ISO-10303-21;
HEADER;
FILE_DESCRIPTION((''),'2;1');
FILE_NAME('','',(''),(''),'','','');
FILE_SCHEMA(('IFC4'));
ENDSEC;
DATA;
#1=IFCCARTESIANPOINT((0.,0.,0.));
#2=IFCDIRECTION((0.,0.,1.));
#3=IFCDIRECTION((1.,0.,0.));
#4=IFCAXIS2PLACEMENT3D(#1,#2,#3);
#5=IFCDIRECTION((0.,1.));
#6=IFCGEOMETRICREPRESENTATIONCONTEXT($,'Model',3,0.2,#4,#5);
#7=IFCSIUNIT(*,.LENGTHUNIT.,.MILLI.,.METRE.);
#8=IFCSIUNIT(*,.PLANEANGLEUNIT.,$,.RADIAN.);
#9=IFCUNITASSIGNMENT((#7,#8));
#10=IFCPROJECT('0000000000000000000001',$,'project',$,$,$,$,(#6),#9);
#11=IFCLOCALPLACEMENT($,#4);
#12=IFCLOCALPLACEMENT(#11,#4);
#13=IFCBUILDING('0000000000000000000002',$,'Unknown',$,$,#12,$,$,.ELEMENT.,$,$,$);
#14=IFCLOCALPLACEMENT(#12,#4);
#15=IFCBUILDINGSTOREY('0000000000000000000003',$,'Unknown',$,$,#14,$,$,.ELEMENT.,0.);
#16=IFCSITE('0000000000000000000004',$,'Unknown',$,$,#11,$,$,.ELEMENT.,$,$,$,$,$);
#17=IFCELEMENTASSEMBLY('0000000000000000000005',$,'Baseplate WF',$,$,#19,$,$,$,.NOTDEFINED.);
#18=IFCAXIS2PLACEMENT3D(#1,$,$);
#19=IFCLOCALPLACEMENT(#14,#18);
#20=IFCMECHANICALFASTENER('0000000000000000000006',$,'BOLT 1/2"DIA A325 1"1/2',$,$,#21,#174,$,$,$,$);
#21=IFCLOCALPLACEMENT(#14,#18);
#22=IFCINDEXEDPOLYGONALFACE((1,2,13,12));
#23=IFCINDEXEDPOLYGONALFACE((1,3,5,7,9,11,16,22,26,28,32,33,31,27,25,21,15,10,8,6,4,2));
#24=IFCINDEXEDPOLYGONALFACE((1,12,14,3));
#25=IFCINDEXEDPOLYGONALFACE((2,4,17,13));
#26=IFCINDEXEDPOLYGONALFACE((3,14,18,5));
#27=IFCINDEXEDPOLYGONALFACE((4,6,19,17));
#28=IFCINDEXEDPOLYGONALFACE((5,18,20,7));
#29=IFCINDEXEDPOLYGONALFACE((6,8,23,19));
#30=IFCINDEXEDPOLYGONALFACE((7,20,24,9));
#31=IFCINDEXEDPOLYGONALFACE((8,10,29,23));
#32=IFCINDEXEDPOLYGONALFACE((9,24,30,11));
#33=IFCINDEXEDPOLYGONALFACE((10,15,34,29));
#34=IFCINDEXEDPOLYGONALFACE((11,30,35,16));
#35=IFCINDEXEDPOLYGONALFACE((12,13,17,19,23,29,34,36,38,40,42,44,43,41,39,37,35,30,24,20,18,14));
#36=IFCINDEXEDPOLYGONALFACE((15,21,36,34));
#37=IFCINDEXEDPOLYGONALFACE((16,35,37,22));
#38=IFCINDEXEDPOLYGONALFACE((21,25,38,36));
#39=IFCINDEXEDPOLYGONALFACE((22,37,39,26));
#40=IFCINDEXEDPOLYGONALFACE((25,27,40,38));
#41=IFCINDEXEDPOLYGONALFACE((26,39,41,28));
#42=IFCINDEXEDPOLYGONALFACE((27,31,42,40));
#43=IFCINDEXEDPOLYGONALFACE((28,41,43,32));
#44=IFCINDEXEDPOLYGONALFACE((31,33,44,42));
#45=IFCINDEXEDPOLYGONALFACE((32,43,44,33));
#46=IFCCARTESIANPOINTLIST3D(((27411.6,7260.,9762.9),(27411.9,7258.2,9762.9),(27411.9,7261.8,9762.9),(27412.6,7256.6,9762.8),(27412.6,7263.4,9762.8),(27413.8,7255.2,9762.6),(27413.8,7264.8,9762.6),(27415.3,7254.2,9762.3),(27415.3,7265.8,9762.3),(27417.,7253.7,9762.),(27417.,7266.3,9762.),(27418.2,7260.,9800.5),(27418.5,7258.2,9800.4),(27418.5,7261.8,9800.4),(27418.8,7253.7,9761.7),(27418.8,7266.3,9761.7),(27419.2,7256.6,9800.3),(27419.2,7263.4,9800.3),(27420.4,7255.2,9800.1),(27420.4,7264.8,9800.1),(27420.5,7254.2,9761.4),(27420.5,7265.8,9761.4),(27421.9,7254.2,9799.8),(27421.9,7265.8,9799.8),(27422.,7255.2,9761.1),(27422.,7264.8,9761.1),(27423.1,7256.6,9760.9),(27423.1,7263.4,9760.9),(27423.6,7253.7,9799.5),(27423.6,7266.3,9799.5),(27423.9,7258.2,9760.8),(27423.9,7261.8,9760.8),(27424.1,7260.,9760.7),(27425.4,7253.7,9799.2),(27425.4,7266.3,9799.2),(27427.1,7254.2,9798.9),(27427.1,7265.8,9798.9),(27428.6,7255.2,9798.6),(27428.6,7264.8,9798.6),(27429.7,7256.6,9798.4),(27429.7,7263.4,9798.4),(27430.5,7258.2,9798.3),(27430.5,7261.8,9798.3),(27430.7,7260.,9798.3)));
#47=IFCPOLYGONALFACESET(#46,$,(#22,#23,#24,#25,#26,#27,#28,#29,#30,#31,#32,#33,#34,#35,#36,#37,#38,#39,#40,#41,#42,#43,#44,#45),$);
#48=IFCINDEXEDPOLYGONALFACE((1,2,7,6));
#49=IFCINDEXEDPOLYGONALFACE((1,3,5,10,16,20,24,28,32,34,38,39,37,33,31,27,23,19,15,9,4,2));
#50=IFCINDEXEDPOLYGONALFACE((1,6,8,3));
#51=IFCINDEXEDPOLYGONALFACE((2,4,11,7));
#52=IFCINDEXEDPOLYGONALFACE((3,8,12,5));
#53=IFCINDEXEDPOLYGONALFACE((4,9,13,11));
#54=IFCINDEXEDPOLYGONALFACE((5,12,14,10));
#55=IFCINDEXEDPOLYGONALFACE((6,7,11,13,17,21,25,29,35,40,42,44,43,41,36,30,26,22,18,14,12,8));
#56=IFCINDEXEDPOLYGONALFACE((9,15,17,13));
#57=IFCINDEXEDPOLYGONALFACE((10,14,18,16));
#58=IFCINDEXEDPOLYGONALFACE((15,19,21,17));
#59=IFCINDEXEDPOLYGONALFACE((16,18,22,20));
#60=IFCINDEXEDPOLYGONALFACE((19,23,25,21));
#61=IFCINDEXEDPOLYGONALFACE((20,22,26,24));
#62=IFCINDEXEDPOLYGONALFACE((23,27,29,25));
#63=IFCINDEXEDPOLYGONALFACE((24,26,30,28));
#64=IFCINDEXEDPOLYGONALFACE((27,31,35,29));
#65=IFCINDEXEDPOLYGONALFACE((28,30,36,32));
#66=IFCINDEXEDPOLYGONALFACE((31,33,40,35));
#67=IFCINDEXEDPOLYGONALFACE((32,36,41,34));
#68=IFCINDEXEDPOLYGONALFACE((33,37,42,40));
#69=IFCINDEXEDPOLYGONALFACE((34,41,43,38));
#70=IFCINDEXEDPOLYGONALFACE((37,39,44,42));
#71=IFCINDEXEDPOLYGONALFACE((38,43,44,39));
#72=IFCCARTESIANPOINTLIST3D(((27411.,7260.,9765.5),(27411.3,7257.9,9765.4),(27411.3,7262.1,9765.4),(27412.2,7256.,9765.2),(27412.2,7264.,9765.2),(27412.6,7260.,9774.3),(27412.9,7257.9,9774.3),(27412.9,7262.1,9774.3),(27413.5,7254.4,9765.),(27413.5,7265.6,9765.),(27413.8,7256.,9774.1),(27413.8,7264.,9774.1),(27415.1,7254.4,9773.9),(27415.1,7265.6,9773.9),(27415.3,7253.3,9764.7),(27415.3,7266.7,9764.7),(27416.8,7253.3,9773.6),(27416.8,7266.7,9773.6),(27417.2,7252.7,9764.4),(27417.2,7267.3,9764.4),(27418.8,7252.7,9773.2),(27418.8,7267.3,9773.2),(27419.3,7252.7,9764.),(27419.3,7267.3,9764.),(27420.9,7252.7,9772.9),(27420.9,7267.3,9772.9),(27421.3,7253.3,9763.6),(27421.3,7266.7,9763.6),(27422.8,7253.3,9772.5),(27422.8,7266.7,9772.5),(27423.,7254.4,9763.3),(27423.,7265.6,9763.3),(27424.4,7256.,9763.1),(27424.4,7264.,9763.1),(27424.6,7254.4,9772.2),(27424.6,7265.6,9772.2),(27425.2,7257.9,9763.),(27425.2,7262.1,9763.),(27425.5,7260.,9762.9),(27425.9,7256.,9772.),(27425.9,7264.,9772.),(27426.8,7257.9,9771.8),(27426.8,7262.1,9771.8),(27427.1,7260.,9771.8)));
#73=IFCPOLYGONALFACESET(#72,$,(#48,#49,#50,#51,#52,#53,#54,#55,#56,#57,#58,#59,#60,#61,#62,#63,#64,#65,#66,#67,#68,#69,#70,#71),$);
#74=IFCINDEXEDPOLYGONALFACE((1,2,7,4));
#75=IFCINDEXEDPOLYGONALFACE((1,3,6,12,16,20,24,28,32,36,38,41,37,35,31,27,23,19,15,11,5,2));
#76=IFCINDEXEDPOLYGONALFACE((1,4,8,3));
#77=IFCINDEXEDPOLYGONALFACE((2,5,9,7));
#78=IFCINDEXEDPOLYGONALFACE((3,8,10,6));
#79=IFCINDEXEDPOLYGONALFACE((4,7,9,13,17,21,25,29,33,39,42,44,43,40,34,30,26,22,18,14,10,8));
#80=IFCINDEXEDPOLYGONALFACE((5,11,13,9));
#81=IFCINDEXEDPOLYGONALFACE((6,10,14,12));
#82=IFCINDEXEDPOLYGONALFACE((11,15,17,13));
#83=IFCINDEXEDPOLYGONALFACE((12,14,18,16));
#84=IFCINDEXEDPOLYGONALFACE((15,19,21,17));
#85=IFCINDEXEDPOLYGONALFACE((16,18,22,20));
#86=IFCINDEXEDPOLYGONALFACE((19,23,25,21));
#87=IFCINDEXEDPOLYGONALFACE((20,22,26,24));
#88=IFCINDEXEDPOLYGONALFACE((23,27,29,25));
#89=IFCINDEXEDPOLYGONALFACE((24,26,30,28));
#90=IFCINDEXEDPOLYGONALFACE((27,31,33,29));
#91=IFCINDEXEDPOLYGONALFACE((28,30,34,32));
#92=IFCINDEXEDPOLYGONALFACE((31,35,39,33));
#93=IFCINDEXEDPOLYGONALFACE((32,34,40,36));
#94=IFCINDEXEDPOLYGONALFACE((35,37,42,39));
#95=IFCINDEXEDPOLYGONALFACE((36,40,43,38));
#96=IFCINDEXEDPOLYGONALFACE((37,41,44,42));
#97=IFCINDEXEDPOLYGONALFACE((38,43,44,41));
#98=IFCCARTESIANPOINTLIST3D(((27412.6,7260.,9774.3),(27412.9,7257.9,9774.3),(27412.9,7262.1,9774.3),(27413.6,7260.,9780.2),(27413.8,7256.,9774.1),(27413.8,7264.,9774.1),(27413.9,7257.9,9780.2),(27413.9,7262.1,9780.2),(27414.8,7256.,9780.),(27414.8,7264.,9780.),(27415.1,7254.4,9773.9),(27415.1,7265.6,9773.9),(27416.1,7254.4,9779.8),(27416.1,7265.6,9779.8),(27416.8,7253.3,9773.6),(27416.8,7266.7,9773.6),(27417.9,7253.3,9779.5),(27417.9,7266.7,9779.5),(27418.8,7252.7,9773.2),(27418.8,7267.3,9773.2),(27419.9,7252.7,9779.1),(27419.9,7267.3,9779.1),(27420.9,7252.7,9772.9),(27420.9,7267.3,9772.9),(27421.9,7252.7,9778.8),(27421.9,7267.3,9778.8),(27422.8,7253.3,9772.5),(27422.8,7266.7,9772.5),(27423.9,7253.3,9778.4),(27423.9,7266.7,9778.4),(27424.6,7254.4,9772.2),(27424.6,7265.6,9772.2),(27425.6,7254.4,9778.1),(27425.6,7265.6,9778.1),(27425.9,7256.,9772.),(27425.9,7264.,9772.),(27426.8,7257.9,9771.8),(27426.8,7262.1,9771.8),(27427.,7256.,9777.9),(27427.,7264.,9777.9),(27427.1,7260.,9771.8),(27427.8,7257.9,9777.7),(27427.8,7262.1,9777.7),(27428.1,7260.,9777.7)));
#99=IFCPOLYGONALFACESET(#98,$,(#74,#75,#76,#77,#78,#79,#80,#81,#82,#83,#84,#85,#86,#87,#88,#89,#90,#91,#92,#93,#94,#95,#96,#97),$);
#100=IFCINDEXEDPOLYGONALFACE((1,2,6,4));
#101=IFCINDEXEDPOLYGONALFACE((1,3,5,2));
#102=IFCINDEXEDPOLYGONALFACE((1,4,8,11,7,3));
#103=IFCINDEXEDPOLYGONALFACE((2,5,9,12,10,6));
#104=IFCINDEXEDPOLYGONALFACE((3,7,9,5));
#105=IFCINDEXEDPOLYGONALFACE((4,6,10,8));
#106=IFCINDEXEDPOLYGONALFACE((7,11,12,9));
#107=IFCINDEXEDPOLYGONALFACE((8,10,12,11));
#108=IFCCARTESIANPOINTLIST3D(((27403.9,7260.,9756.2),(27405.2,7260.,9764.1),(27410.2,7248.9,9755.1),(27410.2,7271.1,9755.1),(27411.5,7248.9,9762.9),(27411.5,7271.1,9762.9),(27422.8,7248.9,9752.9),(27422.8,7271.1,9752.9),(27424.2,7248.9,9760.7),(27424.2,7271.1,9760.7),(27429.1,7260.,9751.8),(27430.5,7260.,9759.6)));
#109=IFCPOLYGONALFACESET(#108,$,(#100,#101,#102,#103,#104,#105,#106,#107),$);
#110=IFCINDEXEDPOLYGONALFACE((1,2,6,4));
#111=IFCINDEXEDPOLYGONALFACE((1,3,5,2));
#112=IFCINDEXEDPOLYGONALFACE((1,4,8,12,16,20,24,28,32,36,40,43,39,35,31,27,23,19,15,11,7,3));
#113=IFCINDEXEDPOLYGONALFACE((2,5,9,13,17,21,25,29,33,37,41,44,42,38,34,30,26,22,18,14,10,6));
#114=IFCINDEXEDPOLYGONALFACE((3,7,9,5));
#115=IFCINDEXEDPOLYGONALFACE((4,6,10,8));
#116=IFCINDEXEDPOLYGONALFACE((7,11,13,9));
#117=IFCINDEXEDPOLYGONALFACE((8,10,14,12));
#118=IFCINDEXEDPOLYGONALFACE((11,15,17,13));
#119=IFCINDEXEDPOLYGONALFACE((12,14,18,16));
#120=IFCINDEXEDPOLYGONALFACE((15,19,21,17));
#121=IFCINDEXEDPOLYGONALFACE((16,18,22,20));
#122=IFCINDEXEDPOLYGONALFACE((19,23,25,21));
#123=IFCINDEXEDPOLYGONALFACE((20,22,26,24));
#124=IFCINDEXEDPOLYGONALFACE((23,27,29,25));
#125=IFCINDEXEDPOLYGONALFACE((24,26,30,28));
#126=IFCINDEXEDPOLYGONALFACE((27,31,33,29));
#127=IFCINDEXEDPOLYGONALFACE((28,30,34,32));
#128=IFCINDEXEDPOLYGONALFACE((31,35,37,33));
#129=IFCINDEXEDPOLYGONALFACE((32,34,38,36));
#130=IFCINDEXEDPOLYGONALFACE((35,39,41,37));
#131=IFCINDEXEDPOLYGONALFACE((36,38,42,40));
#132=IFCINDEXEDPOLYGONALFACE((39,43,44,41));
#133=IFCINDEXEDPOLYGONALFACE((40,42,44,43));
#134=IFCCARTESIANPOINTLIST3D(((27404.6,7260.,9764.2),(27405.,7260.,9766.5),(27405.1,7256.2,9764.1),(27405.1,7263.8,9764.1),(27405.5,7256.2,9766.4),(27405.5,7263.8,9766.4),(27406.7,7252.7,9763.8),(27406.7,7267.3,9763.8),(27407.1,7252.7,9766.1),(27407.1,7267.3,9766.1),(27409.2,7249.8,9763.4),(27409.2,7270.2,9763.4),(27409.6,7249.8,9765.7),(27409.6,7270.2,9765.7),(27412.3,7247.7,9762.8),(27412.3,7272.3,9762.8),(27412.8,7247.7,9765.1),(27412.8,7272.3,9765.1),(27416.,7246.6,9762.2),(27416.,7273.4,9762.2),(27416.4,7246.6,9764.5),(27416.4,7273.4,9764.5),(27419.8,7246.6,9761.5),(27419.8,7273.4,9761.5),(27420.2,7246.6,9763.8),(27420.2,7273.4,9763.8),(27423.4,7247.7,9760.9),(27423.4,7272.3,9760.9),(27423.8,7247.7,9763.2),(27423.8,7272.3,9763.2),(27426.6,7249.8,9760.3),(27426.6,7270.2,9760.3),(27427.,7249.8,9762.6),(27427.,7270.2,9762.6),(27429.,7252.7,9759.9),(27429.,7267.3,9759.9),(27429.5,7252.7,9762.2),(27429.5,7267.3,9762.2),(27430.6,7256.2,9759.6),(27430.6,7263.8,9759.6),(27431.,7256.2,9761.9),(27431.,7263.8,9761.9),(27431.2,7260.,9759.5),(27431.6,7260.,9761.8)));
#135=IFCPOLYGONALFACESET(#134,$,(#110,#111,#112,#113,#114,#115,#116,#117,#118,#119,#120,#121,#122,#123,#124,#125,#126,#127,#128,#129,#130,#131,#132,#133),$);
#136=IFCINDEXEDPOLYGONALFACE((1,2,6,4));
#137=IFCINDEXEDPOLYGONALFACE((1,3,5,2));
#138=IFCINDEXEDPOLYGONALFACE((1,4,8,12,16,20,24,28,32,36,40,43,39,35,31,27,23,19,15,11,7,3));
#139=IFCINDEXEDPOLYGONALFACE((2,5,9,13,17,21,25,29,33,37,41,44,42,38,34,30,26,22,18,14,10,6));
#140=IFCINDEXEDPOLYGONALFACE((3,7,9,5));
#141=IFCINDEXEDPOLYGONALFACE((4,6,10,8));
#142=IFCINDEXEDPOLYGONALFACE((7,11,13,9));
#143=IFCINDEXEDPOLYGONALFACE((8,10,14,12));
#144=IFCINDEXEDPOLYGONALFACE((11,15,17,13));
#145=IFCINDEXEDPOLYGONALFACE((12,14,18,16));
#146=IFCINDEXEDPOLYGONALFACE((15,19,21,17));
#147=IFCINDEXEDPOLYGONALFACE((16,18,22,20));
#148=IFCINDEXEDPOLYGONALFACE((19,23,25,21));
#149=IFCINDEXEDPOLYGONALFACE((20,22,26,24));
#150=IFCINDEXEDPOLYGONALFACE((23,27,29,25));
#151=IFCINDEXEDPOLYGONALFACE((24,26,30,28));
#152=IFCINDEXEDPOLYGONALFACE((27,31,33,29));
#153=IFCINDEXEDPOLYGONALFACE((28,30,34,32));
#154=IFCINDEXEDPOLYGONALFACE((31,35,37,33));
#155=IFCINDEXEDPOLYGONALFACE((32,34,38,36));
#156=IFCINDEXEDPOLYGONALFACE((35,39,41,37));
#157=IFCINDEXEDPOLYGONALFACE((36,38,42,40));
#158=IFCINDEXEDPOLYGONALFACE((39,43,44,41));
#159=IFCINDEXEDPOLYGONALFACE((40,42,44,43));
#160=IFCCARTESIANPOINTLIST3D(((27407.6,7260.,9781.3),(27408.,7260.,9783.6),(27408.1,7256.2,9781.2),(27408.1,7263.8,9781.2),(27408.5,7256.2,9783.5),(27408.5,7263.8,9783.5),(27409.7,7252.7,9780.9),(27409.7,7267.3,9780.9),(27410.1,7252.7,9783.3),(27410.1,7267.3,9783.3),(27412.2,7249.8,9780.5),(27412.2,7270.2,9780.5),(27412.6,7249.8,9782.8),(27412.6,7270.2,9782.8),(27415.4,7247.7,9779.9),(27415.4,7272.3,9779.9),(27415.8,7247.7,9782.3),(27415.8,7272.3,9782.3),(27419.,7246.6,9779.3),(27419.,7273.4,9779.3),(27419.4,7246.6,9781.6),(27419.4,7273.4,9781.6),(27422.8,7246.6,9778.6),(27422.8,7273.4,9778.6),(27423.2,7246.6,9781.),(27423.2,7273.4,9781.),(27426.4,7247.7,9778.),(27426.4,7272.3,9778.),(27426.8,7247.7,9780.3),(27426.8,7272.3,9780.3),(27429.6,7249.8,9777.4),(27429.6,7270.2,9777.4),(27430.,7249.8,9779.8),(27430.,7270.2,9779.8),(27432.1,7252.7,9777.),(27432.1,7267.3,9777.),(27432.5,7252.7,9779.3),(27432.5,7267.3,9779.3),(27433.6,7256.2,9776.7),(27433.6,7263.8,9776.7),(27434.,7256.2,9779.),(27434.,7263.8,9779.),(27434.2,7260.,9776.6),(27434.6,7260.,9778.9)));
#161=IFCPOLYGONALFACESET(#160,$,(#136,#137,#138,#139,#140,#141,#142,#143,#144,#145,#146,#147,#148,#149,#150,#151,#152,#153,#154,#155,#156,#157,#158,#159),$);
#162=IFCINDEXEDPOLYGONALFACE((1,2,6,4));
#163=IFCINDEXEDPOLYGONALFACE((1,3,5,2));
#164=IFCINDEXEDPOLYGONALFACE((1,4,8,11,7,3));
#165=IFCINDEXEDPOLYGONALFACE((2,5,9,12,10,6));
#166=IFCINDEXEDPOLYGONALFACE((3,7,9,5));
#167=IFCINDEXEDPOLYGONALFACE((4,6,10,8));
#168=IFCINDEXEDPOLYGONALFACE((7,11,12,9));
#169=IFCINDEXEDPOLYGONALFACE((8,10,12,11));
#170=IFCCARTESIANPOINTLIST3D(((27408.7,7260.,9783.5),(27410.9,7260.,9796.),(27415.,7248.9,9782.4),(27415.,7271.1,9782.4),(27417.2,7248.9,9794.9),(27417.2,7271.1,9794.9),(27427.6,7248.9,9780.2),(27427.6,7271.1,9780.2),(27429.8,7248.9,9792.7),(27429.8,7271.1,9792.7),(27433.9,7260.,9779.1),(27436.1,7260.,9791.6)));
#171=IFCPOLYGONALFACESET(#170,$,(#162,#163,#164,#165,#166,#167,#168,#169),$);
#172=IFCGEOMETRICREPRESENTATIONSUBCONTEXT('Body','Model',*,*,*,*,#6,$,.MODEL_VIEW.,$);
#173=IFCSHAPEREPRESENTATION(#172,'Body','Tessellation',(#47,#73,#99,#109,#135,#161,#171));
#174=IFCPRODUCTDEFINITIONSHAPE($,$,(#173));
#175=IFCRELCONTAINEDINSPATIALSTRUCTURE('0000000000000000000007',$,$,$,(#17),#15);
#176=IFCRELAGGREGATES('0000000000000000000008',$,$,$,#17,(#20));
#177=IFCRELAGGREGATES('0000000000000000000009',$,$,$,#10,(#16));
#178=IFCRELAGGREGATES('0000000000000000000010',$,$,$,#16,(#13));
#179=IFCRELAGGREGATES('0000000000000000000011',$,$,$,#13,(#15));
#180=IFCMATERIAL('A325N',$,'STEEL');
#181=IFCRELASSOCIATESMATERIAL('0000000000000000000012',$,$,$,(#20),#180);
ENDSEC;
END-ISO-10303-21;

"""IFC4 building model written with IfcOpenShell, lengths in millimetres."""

from ifc_helpers import new_model, si_unit, direction, frame, origin_with_axes, place, context, subcontext, project, spatial, line, arc, indexed_curve, outline, extrude, source, transform, mapped, material, element, aggregate, save


model = new_model("IFC4")

# Units and contexts
model_context = context("Model", 3, precision=0.2, world=origin_with_axes(), true_north=direction((0.0, 1.0)))
body_context = subcontext(model_context, "Body", "Model", "MODEL_VIEW")
ifc_project = project(units=[si_unit("LENGTHUNIT", "METRE", prefix="MILLI"), si_unit("PLANEANGLEUNIT", "RADIAN")], contexts=[model_context])

# Site, building, storey
site_placement = place(None, origin_with_axes())
site = spatial("IfcSite", under=ifc_project, at=site_placement, Name="Unknown", CompositionType="ELEMENT")
building_placement = place(site_placement, origin_with_axes())
building = spatial("IfcBuilding", under=site, at=building_placement, Name="Unknown", CompositionType="ELEMENT")
storey_placement = place(building_placement, origin_with_axes())
storey = spatial("IfcBuildingStorey", under=building, at=storey_placement, Name="Unknown", CompositionType="ELEMENT", Elevation=0.0)

# Shared definitions
ifc_material_1 = material(Name="A325N", Category="STEEL")
shared_shape_1 = source(origin_with_axes(), body_context, "Body", "SweptSolid", [
    extrude(outline(indexed_curve([(6.3, 0.0), (0.0, 6.3), (-6.3, 0.0), (0.0, -6.3)], segments=[arc(1, 2, 3), arc(3, 4, 1)])), frame((0.0, 0.0, 17.4), z_axis=(0.0, 0.0, -1.0), x_axis=(0.0, 1.0, 0.0)), (0.0, 0.0, 1.0), 38.1),
    extrude(outline(indexed_curve([(7.3, 0.0), (0.0, 7.3), (-7.3, 0.0), (0.0, -7.3)], segments=[arc(1, 2, 3), arc(3, 4, 1)])), frame((0.0, 0.0, 15.0), z_axis=(0.0, 0.0, -1.0), x_axis=(0.0, 1.0, 0.0)), (0.0, 0.0, 1.0), 9.0),
    extrude(outline(indexed_curve([(7.3, 0.0), (0.0, 7.3), (-7.3, 0.0), (0.0, -7.3)], segments=[arc(1, 2, 3), arc(3, 4, 1)])), frame((0.0, 0.0, 6.0), z_axis=(0.0, 0.0, -1.0), x_axis=(0.0, 1.0, 0.0)), (0.0, 0.0, 1.0), 6.0),
    extrude(outline(indexed_curve([(12.8, 0.0), (6.4, 11.1), (-6.4, 11.1), (-12.8, 0.0), (-6.4, -11.1), (6.4, -11.1)], segments=[line(1, 2, 3, 4, 5, 6, 1)])), frame((0.0, 0.0, 25.3), z_axis=(0.0, 0.0, -1.0), x_axis=(0.0, 1.0, 0.0)), (0.0, 0.0, 1.0), 7.9),
    extrude(outline(indexed_curve([(13.5, 0.0), (0.0, 13.5), (-13.5, 0.0), (0.0, -13.5)], segments=[arc(1, 2, 3), arc(3, 4, 1)])), frame((0.0, 0.0, 17.4), z_axis=(0.0, 0.0, -1.0), x_axis=(0.0, 1.0, 0.0)), (0.0, 0.0, 1.0), 2.4),
    extrude(outline(indexed_curve([(13.5, 0.0), (0.0, 13.5), (-13.5, 0.0), (0.0, -13.5)], segments=[arc(1, 2, 3), arc(3, 4, 1)])), frame((0.0, 0.0, 0.0), z_axis=(0.0, 0.0, -1.0), x_axis=(0.0, 1.0, 0.0)), (0.0, 0.0, 1.0), 2.4),
    extrude(outline(indexed_curve([(12.8, 0.0), (6.4, 11.1), (-6.4, 11.1), (-12.8, 0.0), (-6.4, -11.1), (6.4, -11.1)], segments=[line(1, 2, 3, 4, 5, 6, 1)])), frame((0.0, 0.0, -2.4), z_axis=(0.0, 0.0, -1.0), x_axis=(0.0, 1.0, 0.0)), (0.0, 0.0, 1.0), 12.7),
])

# Element assembly, mechanical fastener
assembly_1_placement = place(storey_placement, frame((27449.9, 7290.0, 9770.8), z_axis=(-0.173648, 0.0, -0.984808), x_axis=(0.0, -1.0, 0.0)))
assembly_1 = element("IfcElementAssembly", 1, at=assembly_1_placement, inside=storey, Name="Baseplate WF", PredefinedType="NOTDEFINED")
mechanical_fastener_1_placement = place(assembly_1_placement, frame((30.0, 30.0, -3.0), z_axis=(0.0, 0.0, 1.0), x_axis=(-1.0, 0.0, 0.0)))
mechanical_fastener_1 = element("IfcMechanicalFastener", 2, at=mechanical_fastener_1_placement, material=ifc_material_1, Name="BOLT 1/2\"DIA A325 1\"1/2", context=body_context, shape_type="MappedRepresentation", body=[
    mapped(shared_shape_1, transform((0.0, 0.0, 0.0))),
])
aggregate(assembly_1, [mechanical_fastener_1])

save(model, "model.ifc")
